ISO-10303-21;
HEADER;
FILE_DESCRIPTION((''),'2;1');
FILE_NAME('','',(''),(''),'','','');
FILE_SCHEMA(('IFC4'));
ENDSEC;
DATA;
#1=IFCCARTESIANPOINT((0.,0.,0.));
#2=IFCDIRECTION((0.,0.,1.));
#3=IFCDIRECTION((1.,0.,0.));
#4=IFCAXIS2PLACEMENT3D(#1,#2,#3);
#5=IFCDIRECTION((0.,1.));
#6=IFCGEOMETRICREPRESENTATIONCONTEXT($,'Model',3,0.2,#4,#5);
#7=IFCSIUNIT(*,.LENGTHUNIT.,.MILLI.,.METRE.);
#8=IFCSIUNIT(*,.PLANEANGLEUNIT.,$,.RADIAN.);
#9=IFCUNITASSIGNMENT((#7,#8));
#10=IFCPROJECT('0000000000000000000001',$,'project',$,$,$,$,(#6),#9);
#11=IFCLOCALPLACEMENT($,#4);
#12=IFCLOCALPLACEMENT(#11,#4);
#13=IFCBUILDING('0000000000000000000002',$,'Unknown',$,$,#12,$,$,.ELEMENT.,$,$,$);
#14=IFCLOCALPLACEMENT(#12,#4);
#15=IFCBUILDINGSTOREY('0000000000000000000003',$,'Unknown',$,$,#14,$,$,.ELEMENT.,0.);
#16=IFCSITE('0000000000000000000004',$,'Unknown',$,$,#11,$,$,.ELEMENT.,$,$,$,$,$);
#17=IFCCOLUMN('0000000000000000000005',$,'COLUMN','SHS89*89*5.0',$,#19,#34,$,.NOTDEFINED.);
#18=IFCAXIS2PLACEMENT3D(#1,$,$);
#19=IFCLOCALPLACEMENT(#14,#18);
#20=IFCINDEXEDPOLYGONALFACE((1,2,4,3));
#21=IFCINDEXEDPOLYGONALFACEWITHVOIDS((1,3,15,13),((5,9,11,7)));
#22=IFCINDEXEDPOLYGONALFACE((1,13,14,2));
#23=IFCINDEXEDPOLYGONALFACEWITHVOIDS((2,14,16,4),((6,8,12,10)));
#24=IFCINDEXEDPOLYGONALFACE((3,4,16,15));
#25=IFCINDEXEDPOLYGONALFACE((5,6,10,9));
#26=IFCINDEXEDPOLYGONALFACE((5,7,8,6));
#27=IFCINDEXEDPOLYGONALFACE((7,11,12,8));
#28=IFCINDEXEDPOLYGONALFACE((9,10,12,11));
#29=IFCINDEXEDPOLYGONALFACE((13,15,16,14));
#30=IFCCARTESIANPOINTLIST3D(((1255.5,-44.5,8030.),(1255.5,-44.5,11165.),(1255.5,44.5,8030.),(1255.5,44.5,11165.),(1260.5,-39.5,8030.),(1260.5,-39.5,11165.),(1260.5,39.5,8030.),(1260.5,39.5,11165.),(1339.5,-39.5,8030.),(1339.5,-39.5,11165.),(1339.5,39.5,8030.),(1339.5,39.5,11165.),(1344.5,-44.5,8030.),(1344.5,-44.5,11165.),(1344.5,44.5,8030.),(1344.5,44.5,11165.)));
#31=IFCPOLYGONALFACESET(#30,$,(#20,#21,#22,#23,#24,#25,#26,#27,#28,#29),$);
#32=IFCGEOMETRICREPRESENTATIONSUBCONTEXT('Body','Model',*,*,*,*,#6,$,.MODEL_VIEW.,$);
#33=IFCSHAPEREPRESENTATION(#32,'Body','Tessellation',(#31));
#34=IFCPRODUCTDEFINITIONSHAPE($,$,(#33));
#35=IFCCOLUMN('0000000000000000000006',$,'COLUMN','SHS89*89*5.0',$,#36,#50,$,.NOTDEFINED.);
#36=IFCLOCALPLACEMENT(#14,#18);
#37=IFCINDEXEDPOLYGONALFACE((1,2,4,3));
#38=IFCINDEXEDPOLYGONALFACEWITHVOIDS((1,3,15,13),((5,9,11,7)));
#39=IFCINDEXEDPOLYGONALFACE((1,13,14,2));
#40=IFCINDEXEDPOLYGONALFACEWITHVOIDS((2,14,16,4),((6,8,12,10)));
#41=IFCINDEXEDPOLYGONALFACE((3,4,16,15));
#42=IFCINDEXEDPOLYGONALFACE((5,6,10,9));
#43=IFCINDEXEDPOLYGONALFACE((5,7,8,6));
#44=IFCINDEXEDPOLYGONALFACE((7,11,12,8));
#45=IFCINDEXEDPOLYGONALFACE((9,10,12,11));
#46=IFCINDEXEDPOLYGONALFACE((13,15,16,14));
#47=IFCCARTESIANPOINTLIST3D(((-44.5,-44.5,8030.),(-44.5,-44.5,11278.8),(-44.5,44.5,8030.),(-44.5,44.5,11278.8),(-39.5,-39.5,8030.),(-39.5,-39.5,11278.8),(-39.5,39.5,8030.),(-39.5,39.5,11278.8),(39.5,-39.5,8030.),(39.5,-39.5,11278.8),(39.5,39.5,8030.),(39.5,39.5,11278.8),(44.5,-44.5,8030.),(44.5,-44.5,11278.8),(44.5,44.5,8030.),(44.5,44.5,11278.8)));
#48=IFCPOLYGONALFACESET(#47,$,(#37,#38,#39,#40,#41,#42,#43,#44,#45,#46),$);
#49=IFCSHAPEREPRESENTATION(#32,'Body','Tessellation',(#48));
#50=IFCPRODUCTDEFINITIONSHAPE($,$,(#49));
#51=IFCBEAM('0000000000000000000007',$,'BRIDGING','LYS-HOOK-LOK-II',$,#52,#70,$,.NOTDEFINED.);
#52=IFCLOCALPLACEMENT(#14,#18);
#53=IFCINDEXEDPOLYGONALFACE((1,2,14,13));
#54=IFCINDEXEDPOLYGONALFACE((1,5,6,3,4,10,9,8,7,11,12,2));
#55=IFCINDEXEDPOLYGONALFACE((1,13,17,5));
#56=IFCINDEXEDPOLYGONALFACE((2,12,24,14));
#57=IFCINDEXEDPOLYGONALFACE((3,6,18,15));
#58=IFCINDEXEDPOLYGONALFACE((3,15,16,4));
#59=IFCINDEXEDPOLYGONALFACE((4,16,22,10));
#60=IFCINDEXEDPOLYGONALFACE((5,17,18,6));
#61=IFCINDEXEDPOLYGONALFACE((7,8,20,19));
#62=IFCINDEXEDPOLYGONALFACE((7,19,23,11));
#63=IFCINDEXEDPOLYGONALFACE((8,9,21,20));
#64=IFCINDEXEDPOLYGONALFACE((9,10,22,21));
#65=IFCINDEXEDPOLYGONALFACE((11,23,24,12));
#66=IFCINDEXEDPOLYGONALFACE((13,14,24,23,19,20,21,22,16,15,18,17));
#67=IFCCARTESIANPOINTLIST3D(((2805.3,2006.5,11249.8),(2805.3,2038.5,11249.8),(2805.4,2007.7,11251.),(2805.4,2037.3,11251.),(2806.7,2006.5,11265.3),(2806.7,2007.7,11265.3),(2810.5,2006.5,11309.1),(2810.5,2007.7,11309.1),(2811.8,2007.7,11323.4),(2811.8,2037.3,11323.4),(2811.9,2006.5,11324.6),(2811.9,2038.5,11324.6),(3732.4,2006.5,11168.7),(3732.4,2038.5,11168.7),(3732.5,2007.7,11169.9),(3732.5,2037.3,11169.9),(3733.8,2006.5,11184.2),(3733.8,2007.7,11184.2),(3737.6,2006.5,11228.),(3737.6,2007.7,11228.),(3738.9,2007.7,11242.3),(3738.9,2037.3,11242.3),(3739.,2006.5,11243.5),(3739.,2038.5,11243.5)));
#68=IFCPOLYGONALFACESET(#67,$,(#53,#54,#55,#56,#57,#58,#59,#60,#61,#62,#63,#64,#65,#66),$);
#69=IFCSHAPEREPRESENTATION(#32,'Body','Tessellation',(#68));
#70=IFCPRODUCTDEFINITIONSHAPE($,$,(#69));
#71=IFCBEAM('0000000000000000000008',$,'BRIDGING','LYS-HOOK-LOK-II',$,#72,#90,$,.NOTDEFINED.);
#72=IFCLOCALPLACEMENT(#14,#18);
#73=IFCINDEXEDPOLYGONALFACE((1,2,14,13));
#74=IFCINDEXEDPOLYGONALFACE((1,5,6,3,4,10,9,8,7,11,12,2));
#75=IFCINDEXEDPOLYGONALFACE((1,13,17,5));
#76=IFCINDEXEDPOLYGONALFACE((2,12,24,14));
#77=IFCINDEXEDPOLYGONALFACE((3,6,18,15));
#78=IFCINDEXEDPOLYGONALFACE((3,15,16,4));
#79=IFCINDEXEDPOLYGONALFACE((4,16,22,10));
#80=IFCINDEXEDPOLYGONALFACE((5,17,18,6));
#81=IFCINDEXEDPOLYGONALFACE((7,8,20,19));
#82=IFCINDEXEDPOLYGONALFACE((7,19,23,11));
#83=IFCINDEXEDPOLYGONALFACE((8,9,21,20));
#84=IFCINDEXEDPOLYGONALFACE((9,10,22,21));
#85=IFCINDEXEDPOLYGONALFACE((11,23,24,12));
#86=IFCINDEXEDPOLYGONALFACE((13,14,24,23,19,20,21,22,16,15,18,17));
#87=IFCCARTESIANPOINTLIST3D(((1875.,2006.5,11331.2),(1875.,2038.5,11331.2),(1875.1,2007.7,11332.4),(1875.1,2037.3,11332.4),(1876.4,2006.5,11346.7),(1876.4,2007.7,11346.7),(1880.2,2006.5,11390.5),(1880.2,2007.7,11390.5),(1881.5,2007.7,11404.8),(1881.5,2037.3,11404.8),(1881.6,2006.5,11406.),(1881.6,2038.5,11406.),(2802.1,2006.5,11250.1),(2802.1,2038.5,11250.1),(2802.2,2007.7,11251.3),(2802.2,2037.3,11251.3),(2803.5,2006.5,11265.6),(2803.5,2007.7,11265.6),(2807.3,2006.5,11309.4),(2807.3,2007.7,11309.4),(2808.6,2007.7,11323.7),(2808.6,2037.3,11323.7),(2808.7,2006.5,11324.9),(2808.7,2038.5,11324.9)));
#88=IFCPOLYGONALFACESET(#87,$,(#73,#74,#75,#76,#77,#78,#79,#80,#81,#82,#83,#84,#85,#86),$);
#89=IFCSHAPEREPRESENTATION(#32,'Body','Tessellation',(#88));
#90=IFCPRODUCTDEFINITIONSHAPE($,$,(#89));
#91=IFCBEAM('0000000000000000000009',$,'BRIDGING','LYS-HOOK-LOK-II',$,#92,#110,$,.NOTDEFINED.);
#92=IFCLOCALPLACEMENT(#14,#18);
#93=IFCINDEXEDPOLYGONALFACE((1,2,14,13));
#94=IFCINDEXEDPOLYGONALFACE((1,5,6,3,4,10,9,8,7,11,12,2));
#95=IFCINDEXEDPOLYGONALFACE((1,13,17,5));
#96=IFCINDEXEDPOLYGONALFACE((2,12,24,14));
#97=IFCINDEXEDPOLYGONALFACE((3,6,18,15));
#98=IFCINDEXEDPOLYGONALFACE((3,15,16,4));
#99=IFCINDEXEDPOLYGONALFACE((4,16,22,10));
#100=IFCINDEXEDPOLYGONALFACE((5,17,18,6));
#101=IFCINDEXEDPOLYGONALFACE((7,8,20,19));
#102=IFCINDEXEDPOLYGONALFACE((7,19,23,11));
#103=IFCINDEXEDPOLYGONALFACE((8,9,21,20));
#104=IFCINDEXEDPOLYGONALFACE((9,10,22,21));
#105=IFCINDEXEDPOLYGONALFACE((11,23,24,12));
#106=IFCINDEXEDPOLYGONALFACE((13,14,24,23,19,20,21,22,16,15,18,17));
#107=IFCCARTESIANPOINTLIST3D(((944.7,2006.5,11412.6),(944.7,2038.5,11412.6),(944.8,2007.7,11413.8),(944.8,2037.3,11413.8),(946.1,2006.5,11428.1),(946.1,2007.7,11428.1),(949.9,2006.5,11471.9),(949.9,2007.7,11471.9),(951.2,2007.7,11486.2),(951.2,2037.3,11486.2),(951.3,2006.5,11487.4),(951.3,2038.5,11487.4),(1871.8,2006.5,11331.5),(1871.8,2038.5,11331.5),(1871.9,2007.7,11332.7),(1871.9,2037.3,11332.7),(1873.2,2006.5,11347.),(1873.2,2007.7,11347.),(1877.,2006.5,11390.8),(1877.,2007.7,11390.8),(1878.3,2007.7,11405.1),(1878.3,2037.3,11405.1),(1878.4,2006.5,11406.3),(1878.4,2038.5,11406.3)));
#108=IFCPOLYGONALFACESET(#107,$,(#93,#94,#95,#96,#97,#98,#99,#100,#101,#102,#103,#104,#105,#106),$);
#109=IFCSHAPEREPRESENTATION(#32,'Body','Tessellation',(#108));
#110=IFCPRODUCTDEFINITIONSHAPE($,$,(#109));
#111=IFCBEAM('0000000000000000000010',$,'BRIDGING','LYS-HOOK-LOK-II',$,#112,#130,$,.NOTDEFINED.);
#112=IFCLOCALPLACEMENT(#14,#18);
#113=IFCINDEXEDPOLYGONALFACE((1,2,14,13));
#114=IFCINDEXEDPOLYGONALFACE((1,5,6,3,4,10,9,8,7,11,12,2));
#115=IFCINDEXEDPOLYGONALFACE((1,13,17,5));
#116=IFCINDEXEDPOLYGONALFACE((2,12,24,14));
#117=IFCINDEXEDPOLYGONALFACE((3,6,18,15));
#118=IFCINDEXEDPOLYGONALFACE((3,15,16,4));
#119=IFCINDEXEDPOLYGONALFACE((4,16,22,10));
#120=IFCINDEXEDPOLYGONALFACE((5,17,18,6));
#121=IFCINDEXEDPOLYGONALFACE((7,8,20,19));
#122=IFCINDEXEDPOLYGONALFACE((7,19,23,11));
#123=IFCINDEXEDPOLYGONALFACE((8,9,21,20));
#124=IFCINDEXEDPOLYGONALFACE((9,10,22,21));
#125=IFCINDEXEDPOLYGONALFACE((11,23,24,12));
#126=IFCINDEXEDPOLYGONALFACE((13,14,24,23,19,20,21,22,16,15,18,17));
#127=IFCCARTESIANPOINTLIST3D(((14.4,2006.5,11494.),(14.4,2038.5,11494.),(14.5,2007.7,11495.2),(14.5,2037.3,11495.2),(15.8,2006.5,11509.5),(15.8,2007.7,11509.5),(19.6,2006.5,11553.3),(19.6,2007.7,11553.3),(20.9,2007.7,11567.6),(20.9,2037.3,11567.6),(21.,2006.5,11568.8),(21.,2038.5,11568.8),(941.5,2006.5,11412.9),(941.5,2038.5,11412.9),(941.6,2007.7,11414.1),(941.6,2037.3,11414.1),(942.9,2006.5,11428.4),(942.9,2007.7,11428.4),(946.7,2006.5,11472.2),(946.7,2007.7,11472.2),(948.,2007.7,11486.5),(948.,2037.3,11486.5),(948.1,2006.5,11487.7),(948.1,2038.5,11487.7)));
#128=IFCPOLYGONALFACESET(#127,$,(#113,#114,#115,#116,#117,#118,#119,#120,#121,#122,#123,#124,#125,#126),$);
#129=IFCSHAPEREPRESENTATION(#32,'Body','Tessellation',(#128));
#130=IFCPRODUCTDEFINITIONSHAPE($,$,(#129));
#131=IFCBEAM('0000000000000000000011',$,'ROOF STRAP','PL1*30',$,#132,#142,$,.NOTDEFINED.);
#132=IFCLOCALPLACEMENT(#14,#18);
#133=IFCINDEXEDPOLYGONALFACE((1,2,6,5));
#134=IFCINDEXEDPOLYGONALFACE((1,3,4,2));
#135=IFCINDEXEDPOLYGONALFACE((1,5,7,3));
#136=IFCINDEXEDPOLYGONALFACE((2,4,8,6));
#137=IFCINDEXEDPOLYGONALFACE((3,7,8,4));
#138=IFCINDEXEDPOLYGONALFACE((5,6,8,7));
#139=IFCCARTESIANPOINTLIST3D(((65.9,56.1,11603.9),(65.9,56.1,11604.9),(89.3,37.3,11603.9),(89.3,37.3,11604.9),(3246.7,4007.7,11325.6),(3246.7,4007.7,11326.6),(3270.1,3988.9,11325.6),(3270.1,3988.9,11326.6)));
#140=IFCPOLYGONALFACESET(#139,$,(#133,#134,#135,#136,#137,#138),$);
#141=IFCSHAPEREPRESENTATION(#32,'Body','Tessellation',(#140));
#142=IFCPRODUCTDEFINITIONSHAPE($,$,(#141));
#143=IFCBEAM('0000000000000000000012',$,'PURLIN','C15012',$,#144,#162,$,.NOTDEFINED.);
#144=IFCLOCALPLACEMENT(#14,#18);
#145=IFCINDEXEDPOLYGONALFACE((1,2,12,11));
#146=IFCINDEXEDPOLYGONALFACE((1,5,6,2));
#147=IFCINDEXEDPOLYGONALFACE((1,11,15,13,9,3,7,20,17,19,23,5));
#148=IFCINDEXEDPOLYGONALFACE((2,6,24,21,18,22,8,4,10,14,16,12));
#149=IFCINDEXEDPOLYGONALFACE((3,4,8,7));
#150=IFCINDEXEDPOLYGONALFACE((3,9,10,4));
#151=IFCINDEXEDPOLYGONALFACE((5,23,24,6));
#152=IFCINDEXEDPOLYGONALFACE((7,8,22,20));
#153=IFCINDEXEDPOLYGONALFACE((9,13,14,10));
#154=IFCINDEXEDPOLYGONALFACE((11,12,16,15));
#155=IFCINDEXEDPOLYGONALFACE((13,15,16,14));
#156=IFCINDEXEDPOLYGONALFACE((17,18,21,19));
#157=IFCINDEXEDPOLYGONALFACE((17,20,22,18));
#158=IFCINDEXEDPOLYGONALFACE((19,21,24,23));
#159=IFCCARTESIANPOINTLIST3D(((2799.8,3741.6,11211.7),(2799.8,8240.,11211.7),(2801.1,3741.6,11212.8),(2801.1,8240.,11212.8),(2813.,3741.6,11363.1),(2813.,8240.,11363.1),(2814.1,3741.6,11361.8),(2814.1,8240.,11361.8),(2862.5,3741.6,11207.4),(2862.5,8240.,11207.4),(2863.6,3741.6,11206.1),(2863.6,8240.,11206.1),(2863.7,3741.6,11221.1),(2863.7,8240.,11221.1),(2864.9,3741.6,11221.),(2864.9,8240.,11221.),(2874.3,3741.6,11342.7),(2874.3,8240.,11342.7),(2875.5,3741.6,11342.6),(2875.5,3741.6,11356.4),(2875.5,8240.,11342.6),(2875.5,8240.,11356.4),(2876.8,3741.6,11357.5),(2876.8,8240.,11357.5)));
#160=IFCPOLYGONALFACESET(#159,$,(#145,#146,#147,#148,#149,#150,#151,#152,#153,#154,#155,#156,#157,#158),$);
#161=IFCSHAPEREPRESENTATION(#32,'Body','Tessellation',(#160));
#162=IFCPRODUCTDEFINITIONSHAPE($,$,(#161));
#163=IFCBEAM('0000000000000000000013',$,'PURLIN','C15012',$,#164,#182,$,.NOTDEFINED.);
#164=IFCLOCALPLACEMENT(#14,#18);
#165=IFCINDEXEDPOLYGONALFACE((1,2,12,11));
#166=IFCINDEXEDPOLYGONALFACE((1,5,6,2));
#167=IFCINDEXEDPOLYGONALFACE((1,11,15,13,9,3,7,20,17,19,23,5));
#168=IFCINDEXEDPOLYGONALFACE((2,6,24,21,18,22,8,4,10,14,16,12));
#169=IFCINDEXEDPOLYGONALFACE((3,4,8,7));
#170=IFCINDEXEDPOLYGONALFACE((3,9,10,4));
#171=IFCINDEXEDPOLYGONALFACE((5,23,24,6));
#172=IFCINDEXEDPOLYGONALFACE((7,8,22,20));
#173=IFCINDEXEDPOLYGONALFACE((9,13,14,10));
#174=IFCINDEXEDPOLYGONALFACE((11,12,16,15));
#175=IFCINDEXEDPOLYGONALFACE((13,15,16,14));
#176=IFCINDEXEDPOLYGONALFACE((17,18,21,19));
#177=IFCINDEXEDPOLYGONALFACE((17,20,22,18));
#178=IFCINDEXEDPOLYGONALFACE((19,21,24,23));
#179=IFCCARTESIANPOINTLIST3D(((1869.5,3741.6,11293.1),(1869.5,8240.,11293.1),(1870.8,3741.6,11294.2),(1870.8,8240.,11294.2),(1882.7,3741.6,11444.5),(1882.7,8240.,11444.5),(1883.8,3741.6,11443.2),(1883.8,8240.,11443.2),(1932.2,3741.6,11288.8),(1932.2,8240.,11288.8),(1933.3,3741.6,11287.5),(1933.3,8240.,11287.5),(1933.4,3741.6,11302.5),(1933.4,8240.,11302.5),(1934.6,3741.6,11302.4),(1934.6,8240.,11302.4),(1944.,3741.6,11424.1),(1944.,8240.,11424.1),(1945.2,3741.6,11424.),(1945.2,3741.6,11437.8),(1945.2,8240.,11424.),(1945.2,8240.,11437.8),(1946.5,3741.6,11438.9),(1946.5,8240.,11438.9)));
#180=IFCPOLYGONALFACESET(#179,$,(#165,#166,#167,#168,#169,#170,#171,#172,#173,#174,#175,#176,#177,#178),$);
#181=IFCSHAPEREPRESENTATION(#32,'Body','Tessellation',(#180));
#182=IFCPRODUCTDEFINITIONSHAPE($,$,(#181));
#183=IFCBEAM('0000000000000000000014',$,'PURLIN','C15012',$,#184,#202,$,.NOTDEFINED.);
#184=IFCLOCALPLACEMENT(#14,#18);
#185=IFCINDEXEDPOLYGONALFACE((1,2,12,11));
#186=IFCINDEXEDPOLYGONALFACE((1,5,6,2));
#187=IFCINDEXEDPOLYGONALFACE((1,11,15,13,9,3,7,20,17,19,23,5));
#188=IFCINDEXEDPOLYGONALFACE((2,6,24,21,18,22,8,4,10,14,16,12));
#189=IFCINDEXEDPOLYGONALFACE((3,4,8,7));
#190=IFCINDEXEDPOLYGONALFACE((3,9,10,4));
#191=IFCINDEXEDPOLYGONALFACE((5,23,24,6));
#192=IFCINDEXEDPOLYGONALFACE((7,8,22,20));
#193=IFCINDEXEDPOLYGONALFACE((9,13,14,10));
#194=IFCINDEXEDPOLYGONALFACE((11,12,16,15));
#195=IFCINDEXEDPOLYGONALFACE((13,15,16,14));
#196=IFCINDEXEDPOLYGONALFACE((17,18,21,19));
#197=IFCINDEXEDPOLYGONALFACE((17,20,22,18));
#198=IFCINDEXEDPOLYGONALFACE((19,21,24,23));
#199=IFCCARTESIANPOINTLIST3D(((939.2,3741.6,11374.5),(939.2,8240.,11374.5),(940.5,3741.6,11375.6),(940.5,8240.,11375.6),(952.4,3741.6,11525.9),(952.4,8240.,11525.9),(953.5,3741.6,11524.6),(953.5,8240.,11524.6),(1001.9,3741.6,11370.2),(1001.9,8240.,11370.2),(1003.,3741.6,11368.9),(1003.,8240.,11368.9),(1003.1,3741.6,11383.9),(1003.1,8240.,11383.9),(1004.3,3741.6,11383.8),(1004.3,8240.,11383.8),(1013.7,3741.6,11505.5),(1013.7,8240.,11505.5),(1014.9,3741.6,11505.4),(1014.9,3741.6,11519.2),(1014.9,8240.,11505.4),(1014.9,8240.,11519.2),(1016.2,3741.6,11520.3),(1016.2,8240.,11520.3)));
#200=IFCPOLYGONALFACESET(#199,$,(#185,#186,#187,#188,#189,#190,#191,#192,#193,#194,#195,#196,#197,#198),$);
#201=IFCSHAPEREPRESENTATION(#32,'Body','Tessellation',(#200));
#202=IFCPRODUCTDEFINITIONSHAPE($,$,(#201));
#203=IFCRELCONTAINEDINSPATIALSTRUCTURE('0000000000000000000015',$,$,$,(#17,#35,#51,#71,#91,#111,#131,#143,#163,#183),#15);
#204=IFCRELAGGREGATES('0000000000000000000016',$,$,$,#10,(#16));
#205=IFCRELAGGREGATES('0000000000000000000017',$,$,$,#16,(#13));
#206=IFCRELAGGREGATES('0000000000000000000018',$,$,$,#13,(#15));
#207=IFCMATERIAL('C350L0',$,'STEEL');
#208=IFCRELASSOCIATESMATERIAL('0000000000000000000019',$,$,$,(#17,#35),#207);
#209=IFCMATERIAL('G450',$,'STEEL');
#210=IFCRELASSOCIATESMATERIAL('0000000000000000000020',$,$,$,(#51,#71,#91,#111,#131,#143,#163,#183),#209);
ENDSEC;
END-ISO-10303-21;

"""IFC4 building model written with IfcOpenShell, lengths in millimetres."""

from ifc_helpers import new_model, si_unit, direction, frame, origin_with_axes, place, context, subcontext, project, spatial, line, indexed_curve, outline, extrude, material, element, save


model = new_model("IFC4")

# Units and contexts
model_context = context("Model", 3, precision=0.2, world=origin_with_axes(), true_north=direction((0.0, 1.0)))
body_context = subcontext(model_context, "Body", "Model", "MODEL_VIEW")
ifc_project = project(units=[si_unit("LENGTHUNIT", "METRE", prefix="MILLI"), si_unit("PLANEANGLEUNIT", "RADIAN")], contexts=[model_context])

# Site, building, storey
site_placement = place(None, origin_with_axes())
site = spatial("IfcSite", under=ifc_project, at=site_placement, Name="Unknown", CompositionType="ELEMENT")
building_placement = place(site_placement, origin_with_axes())
building = spatial("IfcBuilding", under=site, at=building_placement, Name="Unknown", CompositionType="ELEMENT")
storey_placement = place(building_placement, origin_with_axes())
storey = spatial("IfcBuildingStorey", under=building, at=storey_placement, Name="Unknown", CompositionType="ELEMENT", Elevation=0.0)

# Columns
ifc_material_1 = material(Name="C350L0", Category="STEEL")
column_1_placement = place(storey_placement, frame((1300.0, 0.0, 8030.0), z_axis=(-1.0, 0.0, 0.0), x_axis=(0.0, 0.0, 1.0)))
element("IfcColumn", 1, at=column_1_placement, inside=storey, material=ifc_material_1, Name="COLUMN", Description="SHS89*89*5.0", PredefinedType="NOTDEFINED", context=body_context, shape_type="SolidModel", body=[
    extrude(outline(indexed_curve([(-44.5, -44.5), (44.5, -44.5), (44.5, 44.5), (-44.5, 44.5)], segments=[line(1, 2, 3, 4, 1)]), holes=[indexed_curve([(-39.5, -39.5), (-39.5, 39.5), (39.5, 39.5), (39.5, -39.5)], segments=[line(1, 2, 3, 4, 1)])]), frame((0.0, 0.0, 0.0), z_axis=(-1.0, 0.0, 0.0), x_axis=(0.0, 0.0, 1.0)), (0.0, 0.0, -1.0), 3135.0),
])
column_2_placement = place(storey_placement, frame((0.0, 0.0, 8030.0), z_axis=(-1.0, 0.0, 0.0), x_axis=(0.0, 0.0, 1.0)))
element("IfcColumn", 2, at=column_2_placement, inside=storey, material=ifc_material_1, Name="COLUMN", Description="SHS89*89*5.0", PredefinedType="NOTDEFINED", context=body_context, shape_type="SolidModel", body=[
    extrude(outline(indexed_curve([(-44.5, -44.5), (44.5, -44.5), (44.5, 44.5), (-44.5, 44.5)], segments=[line(1, 2, 3, 4, 1)]), holes=[indexed_curve([(-39.5, -39.5), (-39.5, 39.5), (39.5, 39.5), (39.5, -39.5)], segments=[line(1, 2, 3, 4, 1)])]), frame((0.0, 0.0, 0.0), z_axis=(-1.0, 0.0, 0.0), x_axis=(0.0, 0.0, 1.0)), (0.0, 0.0, -1.0), 3248.8),
])

# Beams
ifc_material_2 = material(Name="G450", Category="STEEL")
for number, where, z_axis, x_axis, name in (
    (3, (2808.6, 2022.5, 11287.2), (0.0, -1.0, 0.0), (0.996196, 0.0, -0.087144), "BRIDGING"),
    (4, (1878.3, 2022.5, 11368.6), (0.0, -1.0, 0.0), (0.996196, 0.0, -0.087144), "BRIDGING"),
    (5, (948.0, 2022.5, 11450.0), (0.0, -1.0, 0.0), (0.996196, 0.0, -0.087144), "BRIDGING"),
    (6, (17.7, 2022.5, 11531.4), (0.0, -1.0, 0.0), (0.996196, 0.0, -0.087144), "BRIDGING"),
):
    element("IfcBeam", number, at=place(storey_placement, frame(where, z_axis=z_axis, x_axis=x_axis)), inside=storey, material=ifc_material_2, Name=name, Description="LYS-HOOK-LOK-II", PredefinedType="NOTDEFINED", context=body_context, shape_type="SolidModel", body=[
        extrude(outline(indexed_curve([(16.0, -37.5), (16.0, -22.0), (14.8, -22.0), (14.8, -36.3), (-14.8, -36.3), (-14.8, 36.3), (14.8, 36.3), (14.8, 22.0), (16.0, 22.0), (16.0, 37.5), (-16.0, 37.5), (-16.0, -37.5)], segments=[line(1, 2, 3, 4, 5, 6, 7, 8, 9, 10, 11, 12, 1)])), frame((0.0, 0.0, 0.0), z_axis=(-1.0, 0.0, 0.0), x_axis=(0.0, 0.0, 1.0)), (0.0, 0.0, -1.0), 930.6),
    ])
beam_1_placement = place(storey_placement, frame((77.6, 46.7, 11604.4), z_axis=(0.034349, 0.042673, 0.998498), x_axis=(0.626097, 0.777819, -0.05478)))
element("IfcBeam", 7, at=beam_1_placement, inside=storey, material=ifc_material_2, Name="ROOF STRAP", Description="PL1*30", PredefinedType="NOTDEFINED", context=body_context, shape_type="SolidModel", body=[
    extrude(outline(indexed_curve([(-0.5, -15.0), (0.5, -15.0), (0.5, 15.0), (-0.5, 15.0)], segments=[line(1, 2, 3, 4, 1)])), frame((0.0, 0.0, 0.0), z_axis=(-1.0, 0.0, 0.0), x_axis=(0.0, 0.0, 1.0)), (0.0, 0.0, -1.0), 5080.4),
])
for number, where, z_axis, x_axis, name in (
    (8, (2838.3, 3741.6, 11284.6), (0.996195, 0.0, -0.087156), (0.0, 1.0, 0.0), "PURLIN"),
    (9, (1908.0, 3741.6, 11366.0), (0.996195, 0.0, -0.087156), (0.0, 1.0, 0.0), "PURLIN"),
    (10, (977.7, 3741.6, 11447.4), (0.996195, 0.0, -0.087156), (0.0, 1.0, 0.0), "PURLIN"),
):
    element("IfcBeam", number, at=place(storey_placement, frame(where, z_axis=z_axis, x_axis=x_axis)), inside=storey, material=ifc_material_2, Name=name, Description="C15012", PredefinedType="NOTDEFINED", context=body_context, shape_type="SolidModel", body=[
        extrude(outline(indexed_curve([(32.0, -76.0), (32.0, -61.0), (30.8, -61.0), (30.8, -74.8), (-30.8, -74.8), (-30.8, 74.8), (30.8, 74.8), (30.8, 61.0), (32.0, 61.0), (32.0, 76.0), (-32.0, 76.0), (-32.0, -76.0)], segments=[line(1, 2, 3, 4, 5, 6, 7, 8, 9, 10, 11, 12, 1)])), frame((0.0, 0.0, 0.0), z_axis=(-1.0, 0.0, 0.0), x_axis=(0.0, 0.0, 1.0)), (0.0, 0.0, -1.0), 4498.4),
    ])

save(model, "model.ifc")
